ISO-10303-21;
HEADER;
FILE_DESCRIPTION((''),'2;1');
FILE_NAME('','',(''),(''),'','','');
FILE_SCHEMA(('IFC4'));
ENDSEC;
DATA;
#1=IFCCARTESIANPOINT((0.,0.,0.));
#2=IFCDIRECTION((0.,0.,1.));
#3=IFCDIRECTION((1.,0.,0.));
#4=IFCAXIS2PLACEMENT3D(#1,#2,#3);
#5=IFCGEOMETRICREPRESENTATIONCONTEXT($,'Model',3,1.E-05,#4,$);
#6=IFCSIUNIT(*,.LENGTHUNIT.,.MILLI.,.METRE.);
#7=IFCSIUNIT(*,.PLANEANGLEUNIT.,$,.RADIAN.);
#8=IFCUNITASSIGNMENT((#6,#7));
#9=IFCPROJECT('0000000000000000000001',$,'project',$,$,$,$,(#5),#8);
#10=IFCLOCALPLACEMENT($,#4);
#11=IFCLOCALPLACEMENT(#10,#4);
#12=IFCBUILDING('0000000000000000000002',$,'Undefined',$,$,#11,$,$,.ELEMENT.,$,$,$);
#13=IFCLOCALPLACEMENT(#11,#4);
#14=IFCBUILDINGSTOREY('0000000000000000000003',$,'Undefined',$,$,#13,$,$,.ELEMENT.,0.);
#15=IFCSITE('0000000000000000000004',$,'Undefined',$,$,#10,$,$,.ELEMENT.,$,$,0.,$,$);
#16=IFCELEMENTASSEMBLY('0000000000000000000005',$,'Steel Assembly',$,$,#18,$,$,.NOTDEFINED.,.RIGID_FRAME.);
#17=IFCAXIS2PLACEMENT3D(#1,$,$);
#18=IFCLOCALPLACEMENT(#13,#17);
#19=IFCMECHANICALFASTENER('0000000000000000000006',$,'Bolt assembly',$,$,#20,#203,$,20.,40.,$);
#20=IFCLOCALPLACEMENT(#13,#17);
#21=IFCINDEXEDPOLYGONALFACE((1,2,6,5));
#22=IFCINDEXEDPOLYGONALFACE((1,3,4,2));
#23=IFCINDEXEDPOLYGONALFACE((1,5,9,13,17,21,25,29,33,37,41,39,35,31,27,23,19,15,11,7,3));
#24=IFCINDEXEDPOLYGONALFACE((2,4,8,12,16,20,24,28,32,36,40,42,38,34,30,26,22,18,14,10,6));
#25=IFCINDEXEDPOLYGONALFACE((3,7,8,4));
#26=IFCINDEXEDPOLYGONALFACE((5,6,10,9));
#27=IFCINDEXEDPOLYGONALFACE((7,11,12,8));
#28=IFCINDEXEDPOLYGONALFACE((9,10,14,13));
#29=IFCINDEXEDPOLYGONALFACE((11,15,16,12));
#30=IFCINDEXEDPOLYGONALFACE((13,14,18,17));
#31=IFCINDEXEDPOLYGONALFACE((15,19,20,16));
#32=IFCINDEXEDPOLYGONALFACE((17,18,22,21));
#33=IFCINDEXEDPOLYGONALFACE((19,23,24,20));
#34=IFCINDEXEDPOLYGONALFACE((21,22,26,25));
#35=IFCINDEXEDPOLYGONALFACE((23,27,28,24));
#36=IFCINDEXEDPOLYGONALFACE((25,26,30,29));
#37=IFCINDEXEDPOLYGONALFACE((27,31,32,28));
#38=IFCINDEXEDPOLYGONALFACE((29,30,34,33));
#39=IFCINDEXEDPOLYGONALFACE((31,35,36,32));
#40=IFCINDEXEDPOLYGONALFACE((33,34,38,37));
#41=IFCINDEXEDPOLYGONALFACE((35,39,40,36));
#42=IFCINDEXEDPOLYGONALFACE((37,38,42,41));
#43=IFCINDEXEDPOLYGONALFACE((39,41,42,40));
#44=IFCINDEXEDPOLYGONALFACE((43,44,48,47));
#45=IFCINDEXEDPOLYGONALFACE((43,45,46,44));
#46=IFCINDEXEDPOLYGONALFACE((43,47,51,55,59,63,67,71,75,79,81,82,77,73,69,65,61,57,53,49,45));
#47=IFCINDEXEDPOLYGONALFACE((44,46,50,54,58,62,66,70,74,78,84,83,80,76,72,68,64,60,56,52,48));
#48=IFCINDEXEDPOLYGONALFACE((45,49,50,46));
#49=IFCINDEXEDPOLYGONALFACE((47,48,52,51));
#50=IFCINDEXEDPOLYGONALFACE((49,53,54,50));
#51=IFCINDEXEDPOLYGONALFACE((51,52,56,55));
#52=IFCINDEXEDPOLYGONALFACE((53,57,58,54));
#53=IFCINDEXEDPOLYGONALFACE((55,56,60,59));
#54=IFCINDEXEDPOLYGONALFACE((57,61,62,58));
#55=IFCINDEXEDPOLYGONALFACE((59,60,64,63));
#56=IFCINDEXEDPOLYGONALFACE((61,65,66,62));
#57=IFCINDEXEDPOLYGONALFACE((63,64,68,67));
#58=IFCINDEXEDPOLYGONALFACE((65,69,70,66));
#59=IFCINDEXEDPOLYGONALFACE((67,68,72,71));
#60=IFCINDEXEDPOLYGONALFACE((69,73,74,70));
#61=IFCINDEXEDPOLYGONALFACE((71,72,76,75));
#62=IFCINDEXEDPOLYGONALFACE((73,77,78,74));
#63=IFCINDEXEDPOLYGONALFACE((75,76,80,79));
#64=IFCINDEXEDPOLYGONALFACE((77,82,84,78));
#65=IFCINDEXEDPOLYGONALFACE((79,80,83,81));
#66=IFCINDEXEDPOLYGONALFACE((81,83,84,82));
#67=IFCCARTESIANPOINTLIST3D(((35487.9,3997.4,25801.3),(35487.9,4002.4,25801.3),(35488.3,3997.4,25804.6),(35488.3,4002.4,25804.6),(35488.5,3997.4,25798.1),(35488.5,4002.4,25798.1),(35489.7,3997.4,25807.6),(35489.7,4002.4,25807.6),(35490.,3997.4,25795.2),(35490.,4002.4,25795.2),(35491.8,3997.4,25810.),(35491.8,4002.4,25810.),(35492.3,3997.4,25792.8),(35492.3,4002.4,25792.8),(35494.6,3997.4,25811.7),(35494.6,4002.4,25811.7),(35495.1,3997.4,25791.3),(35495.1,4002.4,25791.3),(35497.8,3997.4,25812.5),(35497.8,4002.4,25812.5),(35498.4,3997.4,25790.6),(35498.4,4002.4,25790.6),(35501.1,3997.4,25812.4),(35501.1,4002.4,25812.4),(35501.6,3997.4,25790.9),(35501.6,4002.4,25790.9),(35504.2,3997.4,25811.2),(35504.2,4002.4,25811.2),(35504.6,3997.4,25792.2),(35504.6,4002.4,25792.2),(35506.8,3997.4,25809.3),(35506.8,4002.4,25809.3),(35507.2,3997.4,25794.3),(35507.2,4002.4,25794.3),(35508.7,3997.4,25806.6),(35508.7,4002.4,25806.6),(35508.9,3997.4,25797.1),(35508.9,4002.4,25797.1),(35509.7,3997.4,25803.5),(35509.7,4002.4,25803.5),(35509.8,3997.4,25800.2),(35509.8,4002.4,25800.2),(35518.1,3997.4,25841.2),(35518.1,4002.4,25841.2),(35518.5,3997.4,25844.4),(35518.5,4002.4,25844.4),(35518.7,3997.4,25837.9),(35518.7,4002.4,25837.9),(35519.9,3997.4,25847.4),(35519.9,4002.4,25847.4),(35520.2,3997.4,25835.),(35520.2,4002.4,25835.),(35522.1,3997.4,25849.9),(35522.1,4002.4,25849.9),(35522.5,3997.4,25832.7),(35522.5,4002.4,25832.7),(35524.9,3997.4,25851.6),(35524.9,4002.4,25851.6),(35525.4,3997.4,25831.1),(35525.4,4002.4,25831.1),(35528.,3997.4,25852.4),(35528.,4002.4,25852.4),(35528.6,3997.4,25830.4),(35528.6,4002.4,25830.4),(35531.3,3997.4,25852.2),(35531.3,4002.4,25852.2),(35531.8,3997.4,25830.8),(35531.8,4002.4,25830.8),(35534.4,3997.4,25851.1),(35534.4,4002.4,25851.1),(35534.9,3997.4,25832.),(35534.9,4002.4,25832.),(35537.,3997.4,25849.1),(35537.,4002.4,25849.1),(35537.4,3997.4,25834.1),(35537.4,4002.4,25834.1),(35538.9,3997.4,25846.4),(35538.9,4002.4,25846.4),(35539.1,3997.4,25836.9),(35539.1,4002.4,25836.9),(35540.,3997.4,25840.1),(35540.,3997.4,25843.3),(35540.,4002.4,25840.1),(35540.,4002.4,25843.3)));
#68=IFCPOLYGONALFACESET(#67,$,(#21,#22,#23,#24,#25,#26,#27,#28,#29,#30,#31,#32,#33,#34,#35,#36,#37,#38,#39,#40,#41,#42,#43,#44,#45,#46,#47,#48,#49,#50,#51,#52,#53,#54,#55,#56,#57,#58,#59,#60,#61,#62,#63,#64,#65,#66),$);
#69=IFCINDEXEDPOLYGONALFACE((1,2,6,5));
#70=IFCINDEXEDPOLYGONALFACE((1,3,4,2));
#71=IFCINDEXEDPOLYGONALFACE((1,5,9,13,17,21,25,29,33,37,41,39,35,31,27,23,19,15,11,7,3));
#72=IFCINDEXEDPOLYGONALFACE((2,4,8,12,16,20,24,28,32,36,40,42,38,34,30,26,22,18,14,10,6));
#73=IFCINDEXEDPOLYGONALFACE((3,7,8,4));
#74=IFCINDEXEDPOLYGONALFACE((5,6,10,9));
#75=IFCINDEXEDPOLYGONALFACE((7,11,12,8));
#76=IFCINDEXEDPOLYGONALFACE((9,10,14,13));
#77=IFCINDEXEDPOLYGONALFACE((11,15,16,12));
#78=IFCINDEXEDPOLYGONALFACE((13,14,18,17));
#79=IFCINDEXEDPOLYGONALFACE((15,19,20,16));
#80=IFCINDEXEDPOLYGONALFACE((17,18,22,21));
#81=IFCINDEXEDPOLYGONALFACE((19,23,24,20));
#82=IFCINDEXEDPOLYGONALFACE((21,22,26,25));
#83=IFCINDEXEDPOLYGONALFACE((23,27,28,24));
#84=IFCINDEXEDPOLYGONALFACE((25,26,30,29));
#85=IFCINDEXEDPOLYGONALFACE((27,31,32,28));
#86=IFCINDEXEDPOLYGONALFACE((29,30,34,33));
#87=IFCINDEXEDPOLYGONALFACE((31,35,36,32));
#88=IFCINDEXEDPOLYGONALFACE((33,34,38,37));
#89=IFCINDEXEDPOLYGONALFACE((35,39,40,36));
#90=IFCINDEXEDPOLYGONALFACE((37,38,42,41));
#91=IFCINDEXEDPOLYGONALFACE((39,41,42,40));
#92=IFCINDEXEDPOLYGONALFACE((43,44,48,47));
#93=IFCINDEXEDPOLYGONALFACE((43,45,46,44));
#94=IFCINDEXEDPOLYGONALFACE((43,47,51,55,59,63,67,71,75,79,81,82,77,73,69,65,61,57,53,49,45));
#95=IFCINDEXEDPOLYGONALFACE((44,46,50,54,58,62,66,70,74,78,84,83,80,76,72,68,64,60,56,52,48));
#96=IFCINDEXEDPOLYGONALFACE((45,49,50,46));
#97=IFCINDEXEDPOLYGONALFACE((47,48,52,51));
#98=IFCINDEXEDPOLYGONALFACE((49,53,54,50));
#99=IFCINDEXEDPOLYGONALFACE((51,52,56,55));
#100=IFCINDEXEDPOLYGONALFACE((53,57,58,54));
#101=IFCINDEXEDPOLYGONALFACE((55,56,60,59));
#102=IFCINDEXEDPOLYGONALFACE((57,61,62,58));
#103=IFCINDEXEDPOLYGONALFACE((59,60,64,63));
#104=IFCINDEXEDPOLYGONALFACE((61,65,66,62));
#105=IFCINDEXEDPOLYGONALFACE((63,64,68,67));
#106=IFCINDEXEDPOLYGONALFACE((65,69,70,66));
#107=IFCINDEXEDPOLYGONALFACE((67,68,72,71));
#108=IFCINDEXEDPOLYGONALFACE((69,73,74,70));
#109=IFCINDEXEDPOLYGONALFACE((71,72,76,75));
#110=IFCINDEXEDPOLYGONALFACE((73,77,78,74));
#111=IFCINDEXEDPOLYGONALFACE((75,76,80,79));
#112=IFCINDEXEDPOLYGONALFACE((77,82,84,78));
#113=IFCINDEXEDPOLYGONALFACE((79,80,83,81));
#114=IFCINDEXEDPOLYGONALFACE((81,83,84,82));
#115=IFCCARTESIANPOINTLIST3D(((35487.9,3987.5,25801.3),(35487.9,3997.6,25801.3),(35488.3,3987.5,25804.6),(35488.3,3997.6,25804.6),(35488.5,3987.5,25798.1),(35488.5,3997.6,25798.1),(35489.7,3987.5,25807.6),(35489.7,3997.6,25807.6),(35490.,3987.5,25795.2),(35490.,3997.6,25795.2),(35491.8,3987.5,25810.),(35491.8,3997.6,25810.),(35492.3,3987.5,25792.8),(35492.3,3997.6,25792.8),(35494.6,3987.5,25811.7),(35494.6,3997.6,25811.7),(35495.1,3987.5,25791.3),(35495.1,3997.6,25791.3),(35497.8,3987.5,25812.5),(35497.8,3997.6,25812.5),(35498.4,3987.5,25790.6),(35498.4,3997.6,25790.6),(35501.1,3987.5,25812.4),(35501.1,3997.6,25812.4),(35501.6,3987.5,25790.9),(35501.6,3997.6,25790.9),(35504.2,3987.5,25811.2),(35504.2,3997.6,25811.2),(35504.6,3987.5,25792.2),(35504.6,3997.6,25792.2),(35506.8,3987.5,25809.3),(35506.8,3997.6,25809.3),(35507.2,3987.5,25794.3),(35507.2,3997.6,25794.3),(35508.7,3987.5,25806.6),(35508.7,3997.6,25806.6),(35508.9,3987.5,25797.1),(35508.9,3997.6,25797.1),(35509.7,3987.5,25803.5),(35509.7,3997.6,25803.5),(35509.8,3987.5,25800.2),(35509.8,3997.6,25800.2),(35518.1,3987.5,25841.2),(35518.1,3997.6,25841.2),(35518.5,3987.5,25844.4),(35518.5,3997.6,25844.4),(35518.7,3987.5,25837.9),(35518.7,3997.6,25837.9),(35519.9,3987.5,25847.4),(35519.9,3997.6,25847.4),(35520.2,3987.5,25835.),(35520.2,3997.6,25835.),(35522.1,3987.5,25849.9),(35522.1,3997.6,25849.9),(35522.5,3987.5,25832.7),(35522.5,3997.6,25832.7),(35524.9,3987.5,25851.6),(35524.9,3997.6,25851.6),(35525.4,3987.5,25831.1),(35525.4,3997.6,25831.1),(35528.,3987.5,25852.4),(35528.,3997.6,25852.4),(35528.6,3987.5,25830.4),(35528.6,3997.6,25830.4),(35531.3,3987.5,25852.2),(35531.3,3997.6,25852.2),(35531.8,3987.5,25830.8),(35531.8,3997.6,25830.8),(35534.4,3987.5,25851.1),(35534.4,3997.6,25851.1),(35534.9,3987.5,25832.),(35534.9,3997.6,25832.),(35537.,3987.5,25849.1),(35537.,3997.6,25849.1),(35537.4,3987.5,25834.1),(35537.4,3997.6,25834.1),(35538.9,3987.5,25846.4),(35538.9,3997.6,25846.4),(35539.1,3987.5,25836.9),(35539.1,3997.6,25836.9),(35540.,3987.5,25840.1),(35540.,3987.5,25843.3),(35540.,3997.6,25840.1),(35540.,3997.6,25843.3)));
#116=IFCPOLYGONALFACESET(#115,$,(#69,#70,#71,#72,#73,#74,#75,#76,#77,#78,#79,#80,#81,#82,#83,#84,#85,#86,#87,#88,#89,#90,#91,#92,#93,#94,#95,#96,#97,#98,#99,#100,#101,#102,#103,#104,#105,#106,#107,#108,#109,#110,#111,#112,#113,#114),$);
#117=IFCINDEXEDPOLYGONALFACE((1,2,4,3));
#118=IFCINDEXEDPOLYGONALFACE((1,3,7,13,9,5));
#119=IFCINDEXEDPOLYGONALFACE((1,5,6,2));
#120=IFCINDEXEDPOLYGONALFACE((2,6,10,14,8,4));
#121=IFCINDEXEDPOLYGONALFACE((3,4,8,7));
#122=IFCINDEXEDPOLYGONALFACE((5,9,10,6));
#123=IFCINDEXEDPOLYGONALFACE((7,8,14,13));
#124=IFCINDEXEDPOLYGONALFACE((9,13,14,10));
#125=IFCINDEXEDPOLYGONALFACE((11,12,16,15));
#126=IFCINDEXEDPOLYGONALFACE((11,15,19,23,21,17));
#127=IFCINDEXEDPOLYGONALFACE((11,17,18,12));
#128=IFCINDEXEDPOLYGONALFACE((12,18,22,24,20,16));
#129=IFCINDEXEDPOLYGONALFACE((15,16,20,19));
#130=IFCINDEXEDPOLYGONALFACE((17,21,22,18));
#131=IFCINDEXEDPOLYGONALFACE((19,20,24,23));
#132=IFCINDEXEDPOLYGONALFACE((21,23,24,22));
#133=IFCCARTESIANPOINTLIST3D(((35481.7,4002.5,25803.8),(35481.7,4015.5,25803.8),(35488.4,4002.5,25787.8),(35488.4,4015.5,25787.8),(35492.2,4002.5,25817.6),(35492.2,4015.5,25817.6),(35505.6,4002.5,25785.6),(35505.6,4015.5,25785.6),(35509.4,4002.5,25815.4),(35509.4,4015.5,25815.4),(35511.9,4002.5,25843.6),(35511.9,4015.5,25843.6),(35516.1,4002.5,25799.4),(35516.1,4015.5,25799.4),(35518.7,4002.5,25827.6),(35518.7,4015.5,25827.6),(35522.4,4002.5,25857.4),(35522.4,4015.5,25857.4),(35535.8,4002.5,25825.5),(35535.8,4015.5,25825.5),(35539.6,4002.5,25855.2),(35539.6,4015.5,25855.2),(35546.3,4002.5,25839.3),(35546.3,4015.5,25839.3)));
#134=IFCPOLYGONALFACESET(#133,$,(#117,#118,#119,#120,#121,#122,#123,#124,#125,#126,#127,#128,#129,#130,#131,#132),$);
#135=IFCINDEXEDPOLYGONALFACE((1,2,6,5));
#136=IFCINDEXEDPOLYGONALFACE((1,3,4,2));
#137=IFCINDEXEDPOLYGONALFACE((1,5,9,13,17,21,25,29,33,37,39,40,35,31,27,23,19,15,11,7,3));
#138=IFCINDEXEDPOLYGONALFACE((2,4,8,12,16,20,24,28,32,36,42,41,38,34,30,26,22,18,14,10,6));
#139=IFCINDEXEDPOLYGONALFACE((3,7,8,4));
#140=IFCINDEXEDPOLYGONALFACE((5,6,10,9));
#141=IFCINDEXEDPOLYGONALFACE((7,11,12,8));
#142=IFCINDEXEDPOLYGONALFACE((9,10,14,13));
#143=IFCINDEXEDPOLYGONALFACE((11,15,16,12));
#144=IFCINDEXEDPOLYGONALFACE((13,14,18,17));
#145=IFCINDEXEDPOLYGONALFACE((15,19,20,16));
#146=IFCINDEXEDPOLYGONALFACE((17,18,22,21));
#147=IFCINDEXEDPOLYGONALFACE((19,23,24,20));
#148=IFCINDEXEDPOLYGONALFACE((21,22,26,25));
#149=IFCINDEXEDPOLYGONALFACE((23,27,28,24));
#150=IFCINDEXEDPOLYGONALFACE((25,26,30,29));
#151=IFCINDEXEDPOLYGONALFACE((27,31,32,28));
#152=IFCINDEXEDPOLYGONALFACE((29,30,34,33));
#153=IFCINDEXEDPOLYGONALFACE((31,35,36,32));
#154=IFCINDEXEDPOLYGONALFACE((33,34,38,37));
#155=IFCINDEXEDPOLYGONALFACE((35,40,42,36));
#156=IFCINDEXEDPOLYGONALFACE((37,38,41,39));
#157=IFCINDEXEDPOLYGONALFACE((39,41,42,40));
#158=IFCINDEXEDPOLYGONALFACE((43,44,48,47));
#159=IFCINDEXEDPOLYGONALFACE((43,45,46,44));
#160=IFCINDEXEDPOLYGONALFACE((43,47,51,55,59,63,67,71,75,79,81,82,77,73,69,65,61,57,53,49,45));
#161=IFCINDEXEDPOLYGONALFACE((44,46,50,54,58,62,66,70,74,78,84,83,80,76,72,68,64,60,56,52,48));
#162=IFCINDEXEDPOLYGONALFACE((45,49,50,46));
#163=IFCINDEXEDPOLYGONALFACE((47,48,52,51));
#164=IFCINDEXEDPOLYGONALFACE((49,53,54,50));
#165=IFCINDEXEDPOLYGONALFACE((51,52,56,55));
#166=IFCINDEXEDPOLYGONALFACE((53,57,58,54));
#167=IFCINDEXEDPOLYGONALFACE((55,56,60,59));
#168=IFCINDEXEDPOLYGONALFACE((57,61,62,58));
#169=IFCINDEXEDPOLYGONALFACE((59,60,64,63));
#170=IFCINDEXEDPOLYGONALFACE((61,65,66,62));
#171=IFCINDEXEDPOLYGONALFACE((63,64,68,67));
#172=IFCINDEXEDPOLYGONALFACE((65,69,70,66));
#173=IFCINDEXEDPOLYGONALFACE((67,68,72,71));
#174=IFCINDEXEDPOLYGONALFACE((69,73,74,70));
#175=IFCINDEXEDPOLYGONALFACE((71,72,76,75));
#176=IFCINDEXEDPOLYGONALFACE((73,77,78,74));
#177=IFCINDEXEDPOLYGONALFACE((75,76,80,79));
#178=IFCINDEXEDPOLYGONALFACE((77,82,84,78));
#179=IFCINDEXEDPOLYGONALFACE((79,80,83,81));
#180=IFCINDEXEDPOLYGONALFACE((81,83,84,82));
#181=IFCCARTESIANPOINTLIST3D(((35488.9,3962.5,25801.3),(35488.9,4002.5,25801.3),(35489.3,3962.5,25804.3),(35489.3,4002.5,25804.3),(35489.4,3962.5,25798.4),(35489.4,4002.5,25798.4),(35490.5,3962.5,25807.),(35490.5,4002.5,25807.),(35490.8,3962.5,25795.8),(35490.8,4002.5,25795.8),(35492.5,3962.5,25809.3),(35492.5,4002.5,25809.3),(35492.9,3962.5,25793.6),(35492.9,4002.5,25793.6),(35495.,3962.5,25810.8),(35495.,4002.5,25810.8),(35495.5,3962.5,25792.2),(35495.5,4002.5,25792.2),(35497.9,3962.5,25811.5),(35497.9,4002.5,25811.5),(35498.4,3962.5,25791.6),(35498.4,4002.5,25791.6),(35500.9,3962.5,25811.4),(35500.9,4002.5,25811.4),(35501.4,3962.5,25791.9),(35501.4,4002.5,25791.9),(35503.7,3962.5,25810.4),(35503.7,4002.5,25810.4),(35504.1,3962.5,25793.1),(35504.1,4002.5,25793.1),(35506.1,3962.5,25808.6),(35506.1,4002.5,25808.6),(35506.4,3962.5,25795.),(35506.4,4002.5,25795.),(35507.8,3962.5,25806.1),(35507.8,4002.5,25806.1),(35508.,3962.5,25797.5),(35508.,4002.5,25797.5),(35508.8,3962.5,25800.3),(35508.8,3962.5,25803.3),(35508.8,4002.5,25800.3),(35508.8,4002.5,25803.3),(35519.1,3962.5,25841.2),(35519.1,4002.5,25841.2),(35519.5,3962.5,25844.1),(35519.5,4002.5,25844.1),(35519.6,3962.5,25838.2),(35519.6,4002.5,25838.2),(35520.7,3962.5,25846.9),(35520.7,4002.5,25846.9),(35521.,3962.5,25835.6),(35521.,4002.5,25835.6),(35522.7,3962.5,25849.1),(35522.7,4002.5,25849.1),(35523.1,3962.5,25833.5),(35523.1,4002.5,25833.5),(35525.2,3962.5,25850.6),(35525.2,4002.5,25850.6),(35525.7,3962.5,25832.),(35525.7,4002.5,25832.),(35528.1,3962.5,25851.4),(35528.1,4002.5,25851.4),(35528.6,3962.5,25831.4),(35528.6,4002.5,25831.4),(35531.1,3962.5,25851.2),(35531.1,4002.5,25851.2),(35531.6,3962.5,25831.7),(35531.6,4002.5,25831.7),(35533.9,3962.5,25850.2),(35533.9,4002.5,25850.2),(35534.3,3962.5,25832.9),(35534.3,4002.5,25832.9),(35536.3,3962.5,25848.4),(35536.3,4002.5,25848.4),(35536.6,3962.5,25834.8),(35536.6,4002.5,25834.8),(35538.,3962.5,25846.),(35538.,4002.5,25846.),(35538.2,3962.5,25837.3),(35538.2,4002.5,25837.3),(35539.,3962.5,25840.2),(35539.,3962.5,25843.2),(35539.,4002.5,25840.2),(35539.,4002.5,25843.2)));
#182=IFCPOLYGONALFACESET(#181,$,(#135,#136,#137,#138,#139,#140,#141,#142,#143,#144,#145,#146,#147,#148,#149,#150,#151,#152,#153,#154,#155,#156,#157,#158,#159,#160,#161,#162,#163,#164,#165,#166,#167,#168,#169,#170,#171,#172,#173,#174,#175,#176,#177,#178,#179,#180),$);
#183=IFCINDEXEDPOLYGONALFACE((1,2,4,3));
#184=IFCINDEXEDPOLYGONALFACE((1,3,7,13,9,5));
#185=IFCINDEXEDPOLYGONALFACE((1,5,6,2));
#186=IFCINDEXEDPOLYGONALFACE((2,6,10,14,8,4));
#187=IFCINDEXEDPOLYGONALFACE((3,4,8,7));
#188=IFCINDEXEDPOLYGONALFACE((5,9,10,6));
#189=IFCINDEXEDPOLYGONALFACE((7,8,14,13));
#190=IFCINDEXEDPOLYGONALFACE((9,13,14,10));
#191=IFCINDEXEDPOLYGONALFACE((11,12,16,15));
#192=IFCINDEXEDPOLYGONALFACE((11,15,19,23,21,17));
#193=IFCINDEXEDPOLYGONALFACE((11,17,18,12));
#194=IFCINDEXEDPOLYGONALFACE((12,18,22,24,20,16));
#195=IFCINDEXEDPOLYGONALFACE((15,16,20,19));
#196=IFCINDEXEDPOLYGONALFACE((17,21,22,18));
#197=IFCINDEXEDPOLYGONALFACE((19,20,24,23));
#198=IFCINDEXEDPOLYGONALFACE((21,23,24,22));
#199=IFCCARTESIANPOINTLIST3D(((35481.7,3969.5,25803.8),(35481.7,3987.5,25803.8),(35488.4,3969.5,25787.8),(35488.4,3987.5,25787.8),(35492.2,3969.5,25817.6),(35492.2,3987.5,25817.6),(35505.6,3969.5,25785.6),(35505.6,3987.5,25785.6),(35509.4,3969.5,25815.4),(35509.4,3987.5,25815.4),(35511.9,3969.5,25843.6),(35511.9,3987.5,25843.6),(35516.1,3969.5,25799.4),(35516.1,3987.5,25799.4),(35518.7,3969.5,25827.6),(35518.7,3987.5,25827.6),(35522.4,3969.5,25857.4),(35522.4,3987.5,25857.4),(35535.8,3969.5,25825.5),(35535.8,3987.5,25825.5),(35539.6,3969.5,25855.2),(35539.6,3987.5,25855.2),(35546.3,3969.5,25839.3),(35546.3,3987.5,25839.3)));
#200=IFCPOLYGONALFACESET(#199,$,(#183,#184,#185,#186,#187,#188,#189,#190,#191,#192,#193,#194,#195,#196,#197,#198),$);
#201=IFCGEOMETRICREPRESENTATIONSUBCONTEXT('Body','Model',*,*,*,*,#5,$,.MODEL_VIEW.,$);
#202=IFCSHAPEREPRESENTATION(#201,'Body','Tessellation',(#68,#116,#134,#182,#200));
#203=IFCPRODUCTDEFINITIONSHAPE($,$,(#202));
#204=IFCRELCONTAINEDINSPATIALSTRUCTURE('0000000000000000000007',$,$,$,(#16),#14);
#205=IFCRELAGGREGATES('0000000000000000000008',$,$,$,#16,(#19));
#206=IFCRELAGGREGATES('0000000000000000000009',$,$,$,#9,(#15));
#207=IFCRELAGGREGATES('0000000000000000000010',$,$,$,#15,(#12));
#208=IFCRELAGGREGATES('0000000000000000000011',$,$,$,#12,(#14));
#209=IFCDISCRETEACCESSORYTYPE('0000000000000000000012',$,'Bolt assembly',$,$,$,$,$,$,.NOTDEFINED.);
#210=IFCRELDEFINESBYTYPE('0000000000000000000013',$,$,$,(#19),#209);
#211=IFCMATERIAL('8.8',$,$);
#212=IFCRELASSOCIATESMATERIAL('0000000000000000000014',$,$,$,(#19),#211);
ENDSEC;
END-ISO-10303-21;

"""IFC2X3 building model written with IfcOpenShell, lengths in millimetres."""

from ifc_helpers import new_model, si_unit, frame, origin_with_axes, origin_2d_with_axis, place, context, subcontext, project, spatial, polyline, circle, outline, extrude, source, transform, mapped, material, type_object, element, aggregate, save


model = new_model("IFC2X3")

# Units and contexts
model_context = context("Model", 3, precision=1e-05, world=origin_with_axes())
body_context = subcontext(model_context, "Body", "Model", "MODEL_VIEW")
ifc_project = project(units=[si_unit("LENGTHUNIT", "METRE", prefix="MILLI"), si_unit("PLANEANGLEUNIT", "RADIAN")], contexts=[model_context])

# Site, building, storey
site_placement = place(None, origin_with_axes())
site = spatial("IfcSite", under=ifc_project, at=site_placement, Name="Undefined", CompositionType="ELEMENT", RefElevation=0.0)
building_placement = place(site_placement, origin_with_axes())
building = spatial("IfcBuilding", under=site, at=building_placement, Name="Undefined", CompositionType="ELEMENT")
storey_placement = place(building_placement, origin_with_axes())
storey = spatial("IfcBuildingStorey", under=building, at=storey_placement, Name="Undefined", CompositionType="ELEMENT", Elevation=0.0)

# Element assembly
assembly_1_placement = place(storey_placement, origin_with_axes())
assembly_1 = element("IfcElementAssembly", 1, at=assembly_1_placement, inside=storey, Name="Steel Assembly", AssemblyPlace="NOTDEFINED", PredefinedType="RIGID_FRAME")

# Shared definitions
discrete_accessory_type_1 = type_object("IfcDiscreteAccessoryType", Name="Bolt assembly")
ifc_material_1 = material(Name="8.8")

# Mechanical fastener
shared_shape_1 = source(origin_with_axes(), body_context, "Body", "SweptSolid", [
    extrude(circle(Radius=11.0, at=origin_2d_with_axis()), frame((0.0, -2.4, 0.0), z_axis=(0.0, 1.0, 0.0), x_axis=(1.0, 0.0, 0.0)), (0.0, 0.0, 1.0), 5.0),
    extrude(circle(Radius=11.0, at=origin_2d_with_axis()), frame((0.0, 2.4, 0.0), z_axis=(0.0, 1.0, 0.0), x_axis=(1.0, 0.0, 0.0)), (0.0, 0.0, 1.0), 10.1),
    extrude(outline(polyline([(17.3, 0.0), (8.7, 15.0), (-8.7, 15.0), (-17.3, 0.0), (-8.7, -15.0), (8.7, -15.0), (17.3, 0.0)])), frame((0.0, -15.5, 0.0), z_axis=(0.0, 1.0, 0.0), x_axis=(1.0, 0.0, 0.0)), (0.0, 0.0, 1.0), 13.0),
    extrude(circle(Radius=10.0, at=origin_2d_with_axis()), frame((0.0, -2.5, 0.0), z_axis=(0.0, 1.0, 0.0), x_axis=(1.0, 0.0, 0.0)), (0.0, 0.0, 1.0), 40.0),
    extrude(outline(polyline([(17.3, 0.0), (8.7, 15.0), (-8.7, 15.0), (-17.3, 0.0), (-8.7, -15.0), (8.7, -15.0), (17.3, 0.0)])), frame((0.0, 12.5, 0.0), z_axis=(0.0, 1.0, 0.0), x_axis=(1.0, 0.0, 0.0)), (0.0, 0.0, 1.0), 18.0),
])
mechanical_fastener_1_placement = place(assembly_1_placement, frame((35529.1, 4000.0, 25841.4), z_axis=(-0.796808, 0.0, 0.604233), x_axis=(-0.604233, 0.0, -0.796808)))
mechanical_fastener_1 = element("IfcMechanicalFastener", 2, at=mechanical_fastener_1_placement, type_object=discrete_accessory_type_1, material=ifc_material_1, Name="Bolt assembly", NominalDiameter=20.0, NominalLength=40.0, context=body_context, shape_type="MappedRepresentation", body=[
    mapped(shared_shape_1, transform((0.0, 0.0, 0.0))),
    mapped(shared_shape_1, transform((50.0, 0.0, 0.0))),
])
aggregate(assembly_1, [mechanical_fastener_1])

save(model, "model.ifc")
